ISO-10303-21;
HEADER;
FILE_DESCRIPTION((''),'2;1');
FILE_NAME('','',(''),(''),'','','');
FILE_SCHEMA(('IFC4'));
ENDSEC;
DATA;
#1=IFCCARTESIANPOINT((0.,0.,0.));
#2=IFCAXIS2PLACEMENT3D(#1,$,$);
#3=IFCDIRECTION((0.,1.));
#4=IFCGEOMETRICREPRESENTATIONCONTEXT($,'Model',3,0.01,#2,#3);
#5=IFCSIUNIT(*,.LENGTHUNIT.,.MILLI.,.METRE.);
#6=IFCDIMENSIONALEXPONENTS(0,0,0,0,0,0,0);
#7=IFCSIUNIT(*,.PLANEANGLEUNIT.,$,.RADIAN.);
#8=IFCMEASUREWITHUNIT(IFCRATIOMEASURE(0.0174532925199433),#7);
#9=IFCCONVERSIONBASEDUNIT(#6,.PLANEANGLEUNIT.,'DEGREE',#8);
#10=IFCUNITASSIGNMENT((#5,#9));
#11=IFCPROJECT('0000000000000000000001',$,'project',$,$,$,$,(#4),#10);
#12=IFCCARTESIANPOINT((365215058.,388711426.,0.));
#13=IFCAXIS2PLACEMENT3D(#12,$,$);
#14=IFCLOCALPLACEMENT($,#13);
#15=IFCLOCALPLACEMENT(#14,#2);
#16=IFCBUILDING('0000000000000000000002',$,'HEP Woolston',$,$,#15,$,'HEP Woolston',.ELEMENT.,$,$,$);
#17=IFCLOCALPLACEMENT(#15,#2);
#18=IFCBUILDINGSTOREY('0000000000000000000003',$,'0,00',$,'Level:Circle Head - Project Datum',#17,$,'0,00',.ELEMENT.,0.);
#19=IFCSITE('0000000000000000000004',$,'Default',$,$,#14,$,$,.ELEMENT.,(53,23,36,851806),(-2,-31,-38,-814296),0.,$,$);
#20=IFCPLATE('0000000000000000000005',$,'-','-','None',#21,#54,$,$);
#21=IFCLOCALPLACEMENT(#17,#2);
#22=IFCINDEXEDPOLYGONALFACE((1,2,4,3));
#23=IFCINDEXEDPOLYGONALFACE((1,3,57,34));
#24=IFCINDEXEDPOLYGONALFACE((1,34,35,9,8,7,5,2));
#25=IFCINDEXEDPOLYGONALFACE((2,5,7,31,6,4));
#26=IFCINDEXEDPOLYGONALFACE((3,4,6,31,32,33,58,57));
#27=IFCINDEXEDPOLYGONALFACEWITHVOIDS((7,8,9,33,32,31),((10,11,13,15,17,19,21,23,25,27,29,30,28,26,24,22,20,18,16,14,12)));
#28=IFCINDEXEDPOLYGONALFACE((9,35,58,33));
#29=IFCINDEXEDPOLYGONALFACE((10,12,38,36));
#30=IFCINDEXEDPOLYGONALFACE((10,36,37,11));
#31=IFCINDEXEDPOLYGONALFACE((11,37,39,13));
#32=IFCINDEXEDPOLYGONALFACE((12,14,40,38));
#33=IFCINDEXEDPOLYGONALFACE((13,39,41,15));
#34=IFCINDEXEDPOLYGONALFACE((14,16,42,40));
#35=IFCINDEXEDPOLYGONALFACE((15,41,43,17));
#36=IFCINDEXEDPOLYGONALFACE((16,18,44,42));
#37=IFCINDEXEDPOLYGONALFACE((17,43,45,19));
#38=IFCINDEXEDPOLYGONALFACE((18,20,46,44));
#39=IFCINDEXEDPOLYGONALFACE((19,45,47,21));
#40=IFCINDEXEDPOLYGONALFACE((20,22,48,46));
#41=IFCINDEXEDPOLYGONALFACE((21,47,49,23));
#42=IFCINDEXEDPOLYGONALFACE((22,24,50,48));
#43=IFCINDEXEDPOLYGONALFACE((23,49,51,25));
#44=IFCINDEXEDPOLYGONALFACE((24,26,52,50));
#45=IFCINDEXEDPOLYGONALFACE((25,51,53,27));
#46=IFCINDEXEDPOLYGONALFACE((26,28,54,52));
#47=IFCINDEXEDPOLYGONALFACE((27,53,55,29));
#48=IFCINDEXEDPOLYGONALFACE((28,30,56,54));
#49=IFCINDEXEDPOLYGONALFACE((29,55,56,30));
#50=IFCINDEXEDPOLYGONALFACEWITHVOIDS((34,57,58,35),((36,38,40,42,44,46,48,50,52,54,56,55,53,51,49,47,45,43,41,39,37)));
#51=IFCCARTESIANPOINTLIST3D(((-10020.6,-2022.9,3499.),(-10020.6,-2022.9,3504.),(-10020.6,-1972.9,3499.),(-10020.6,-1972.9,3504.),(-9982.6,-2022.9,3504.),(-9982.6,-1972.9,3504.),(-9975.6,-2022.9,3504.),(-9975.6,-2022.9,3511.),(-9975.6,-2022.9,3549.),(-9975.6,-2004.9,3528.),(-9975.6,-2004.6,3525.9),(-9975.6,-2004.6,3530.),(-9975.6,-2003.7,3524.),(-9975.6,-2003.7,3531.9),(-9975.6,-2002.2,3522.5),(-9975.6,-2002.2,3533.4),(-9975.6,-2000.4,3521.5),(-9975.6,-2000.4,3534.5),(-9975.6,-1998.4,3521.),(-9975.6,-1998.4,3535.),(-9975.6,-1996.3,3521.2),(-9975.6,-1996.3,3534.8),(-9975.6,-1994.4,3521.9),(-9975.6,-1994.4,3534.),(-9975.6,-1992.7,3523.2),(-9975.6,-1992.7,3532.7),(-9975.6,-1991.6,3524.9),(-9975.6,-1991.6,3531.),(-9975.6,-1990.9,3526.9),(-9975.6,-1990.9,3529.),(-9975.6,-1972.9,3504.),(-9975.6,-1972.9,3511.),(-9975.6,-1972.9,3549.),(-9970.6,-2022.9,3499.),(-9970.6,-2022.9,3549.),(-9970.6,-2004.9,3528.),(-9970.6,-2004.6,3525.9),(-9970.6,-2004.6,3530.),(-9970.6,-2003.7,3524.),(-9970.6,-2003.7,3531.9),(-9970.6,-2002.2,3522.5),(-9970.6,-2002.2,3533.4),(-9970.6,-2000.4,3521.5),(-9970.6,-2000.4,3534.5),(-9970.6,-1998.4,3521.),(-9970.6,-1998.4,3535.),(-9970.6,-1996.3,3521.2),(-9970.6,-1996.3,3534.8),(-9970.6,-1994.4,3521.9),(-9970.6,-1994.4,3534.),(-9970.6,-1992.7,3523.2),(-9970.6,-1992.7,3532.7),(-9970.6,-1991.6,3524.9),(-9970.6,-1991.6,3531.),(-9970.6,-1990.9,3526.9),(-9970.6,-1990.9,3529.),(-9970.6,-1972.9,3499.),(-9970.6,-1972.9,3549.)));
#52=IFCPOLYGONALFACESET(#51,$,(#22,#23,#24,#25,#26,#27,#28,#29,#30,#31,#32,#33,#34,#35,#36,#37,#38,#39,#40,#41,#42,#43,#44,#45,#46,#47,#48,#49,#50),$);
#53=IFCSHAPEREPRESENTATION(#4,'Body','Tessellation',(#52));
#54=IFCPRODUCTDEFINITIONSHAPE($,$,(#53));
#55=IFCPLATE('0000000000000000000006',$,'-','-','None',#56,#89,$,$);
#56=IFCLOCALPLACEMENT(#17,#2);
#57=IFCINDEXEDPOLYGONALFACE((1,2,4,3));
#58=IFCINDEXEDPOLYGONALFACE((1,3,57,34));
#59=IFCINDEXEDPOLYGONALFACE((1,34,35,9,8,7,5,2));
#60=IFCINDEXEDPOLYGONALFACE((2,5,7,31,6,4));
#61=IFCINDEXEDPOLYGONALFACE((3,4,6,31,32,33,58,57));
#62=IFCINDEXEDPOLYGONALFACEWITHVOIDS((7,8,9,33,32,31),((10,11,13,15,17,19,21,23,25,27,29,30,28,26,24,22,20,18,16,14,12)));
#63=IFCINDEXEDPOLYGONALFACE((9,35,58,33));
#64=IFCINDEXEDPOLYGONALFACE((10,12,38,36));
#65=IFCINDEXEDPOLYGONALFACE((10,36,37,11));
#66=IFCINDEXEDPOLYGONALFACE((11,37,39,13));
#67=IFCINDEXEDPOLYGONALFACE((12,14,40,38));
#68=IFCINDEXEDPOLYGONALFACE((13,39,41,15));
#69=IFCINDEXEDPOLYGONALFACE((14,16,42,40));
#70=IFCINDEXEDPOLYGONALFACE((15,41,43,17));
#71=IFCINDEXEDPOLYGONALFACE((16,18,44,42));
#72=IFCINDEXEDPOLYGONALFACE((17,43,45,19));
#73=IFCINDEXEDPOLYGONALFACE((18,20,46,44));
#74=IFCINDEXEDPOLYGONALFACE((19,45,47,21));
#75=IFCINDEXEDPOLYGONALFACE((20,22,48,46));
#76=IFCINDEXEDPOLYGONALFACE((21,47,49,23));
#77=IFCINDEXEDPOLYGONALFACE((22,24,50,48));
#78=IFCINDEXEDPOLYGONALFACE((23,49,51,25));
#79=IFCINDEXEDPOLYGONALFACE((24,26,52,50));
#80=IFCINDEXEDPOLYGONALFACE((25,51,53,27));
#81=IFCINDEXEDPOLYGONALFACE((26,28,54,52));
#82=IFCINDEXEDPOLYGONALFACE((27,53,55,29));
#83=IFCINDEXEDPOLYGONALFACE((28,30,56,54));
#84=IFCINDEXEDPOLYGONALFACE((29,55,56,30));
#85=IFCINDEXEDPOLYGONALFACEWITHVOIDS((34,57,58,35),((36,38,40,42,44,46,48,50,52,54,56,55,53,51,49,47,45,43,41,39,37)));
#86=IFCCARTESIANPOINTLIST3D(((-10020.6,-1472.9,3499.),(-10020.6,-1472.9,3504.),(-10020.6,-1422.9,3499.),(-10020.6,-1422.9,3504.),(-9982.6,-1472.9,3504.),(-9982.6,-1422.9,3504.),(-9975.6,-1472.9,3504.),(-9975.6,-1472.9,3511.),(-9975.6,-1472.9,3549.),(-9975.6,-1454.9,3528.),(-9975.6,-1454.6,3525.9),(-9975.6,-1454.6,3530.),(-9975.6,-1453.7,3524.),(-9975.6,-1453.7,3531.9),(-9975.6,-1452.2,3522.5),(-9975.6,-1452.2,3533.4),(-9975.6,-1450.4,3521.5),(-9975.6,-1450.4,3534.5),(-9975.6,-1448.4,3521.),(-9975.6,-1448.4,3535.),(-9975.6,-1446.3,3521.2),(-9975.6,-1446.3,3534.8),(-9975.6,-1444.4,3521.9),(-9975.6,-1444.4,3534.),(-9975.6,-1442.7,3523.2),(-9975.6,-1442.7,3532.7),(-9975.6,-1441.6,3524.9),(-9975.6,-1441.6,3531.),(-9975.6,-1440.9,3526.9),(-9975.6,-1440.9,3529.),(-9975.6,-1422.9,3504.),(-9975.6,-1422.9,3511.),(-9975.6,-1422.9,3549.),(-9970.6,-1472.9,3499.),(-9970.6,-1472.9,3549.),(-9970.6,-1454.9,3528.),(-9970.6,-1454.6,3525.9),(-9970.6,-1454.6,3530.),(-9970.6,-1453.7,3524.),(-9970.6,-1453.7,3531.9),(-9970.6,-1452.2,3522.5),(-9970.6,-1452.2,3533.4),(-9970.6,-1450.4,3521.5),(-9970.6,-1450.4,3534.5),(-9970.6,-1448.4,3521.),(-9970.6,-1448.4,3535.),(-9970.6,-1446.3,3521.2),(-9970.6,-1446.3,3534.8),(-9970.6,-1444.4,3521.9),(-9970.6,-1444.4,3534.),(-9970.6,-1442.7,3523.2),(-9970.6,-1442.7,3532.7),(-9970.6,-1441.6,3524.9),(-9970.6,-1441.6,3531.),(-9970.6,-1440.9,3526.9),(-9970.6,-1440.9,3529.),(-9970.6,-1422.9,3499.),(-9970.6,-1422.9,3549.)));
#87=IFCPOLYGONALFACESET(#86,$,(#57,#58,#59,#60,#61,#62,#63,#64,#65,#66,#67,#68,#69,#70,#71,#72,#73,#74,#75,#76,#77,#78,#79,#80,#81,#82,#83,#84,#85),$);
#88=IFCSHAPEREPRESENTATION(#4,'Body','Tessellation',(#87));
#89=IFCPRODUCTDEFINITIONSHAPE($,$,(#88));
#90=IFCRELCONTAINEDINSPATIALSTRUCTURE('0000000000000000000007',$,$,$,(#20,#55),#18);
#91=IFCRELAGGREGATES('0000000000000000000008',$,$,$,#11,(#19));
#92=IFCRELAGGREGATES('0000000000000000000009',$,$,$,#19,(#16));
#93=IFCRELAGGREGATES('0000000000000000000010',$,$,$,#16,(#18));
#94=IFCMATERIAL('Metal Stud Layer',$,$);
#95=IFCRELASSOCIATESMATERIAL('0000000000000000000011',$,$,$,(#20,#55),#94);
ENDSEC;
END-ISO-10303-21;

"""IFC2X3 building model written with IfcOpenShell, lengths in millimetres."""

from ifc_helpers import new_model, entity, si_unit, converted_unit, point, direction, frame, frame_2d, origin, origin_with_axes, origin_2d_with_axis, place, context, project, spatial, polyline, circle_curve, line_curve, trimmed, segment, composite_curve, circle, outline, extrude, material, element, save


model = new_model("IFC2X3")

# Units and contexts
model_context = context("Model", 3, precision=0.01, world=origin(), true_north=direction((0.0, 1.0)))
ifc_project = project(units=[si_unit("LENGTHUNIT", "METRE", prefix="MILLI"), converted_unit("PLANEANGLEUNIT", "DEGREE", entity("IfcRatioMeasure", 0.0174532925199433), si_unit("PLANEANGLEUNIT", "RADIAN"), dimensions=[0, 0, 0, 0, 0, 0, 0])], contexts=[model_context])

# Site, building, storey
site_placement = place(None, frame((365215058.0, 388711426.0, 0.0)))
site = spatial("IfcSite", under=ifc_project, at=site_placement, Name="Default", CompositionType="ELEMENT", RefLatitude=(53, 23, 36, 851806), RefLongitude=(-2, -31, -38, -814296), RefElevation=0.0)
building_placement = place(site_placement, origin())
building = spatial("IfcBuilding", under=site, at=building_placement, Name="HEP Woolston", LongName="HEP Woolston", CompositionType="ELEMENT")
storey_placement = place(building_placement, origin())
storey = spatial("IfcBuildingStorey", under=building, at=storey_placement, Name="0,00", ObjectType="Level:Circle Head - Project Datum", LongName="0,00", CompositionType="ELEMENT", Elevation=0.0)

# Plates, openings
ifc_material = material(Name="Metal Stud Layer")
plate_1_placement = place(storey_placement, frame((-9970.6, -2022.9, 3499.0), z_axis=(0.0, 1.0, 0.0), x_axis=(-1.0, 0.0, 0.0)))
plate_1 = element("IfcPlate", 1, at=plate_1_placement, inside=storey, material=ifc_material, Name="-", Description="-", ObjectType="None", context=model_context, shape_type="SweptSolid", body=[
    extrude(outline(polyline([(0.0, 0.0), (50.0, 0.0), (50.0, 5.0), (5.0, 5.0), (5.0, 50.0), (0.0, 50.0), (0.0, 0.0)])), origin_with_axes(), (0.0, 0.0, 1.0), 50.0),
])
opening_1_placement = place(plate_1_placement, frame((0.0, 0.0, 0.0), z_axis=(0.0, 0.0, 1.0), x_axis=(1.0, 0.0, 0.0)))
element("IfcOpeningElement", 2, at=opening_1_placement, cuts=plate_1, ObjectType="Opening", context=model_context, shape_type="SweptSolid", body=[
    extrude(outline(composite_curve([segment(trimmed(line_curve((50.0, 5.0), (1.0, 0.0), 3.532613), [point((50.0, 5.0))], [point((46.5, 5.0))], True, "CARTESIAN"), True, "CONTINUOUS"), segment(trimmed(circle_curve(frame_2d((46.5, 1.5), x_axis=(-1.0, 0.0)), 3.5), [point((46.5, 5.0))], [point((50.0, 1.5))], False, "CARTESIAN"), True, "CONTINUOUS"), segment(trimmed(line_curve((50.0, 1.5), (0.0, -1.0), 3.532613), [point((50.0, 1.5))], [point((50.0, 5.0))], True, "CARTESIAN"), True, "CONTINUOUS")], self_intersect="UNKNOWN")), origin(), (0.0, 0.0, 1.0), 50.0),
])
opening_2_placement = place(plate_1_placement, origin_with_axes())
element("IfcOpeningElement", 3, at=opening_2_placement, cuts=plate_1, ObjectType="Opening", context=model_context, shape_type="SweptSolid", body=[
    extrude(outline(composite_curve([segment(trimmed(line_curve((5.0, 5.0), (0.0, -1.0), 7.046301), [point((5.0, 5.0))], [point((5.0, 12.0))], False, "CARTESIAN"), True, "CONTINUOUS"), segment(trimmed(circle_curve(frame_2d((12.0, 12.0), x_axis=(1.0, 0.0)), 7.0), [point((5.0, 12.0))], [point((12.0, 5.0))], True, "CARTESIAN"), True, "CONTINUOUS"), segment(trimmed(line_curve((12.0, 5.0), (1.0, 0.0), 7.046301), [point((12.0, 5.0))], [point((5.0, 5.0))], False, "CARTESIAN"), True, "CONTINUOUS")], self_intersect="UNKNOWN")), origin(), (0.0, 0.0, 1.0), 50.0),
])
opening_3_placement = place(plate_1_placement, frame((0.0, 0.0, 0.0), z_axis=(0.0, 0.0, 1.0), x_axis=(1.0, 0.0, 0.0)))
element("IfcOpeningElement", 4, at=opening_3_placement, cuts=plate_1, ObjectType="Opening", context=model_context, shape_type="SweptSolid", body=[
    extrude(outline(composite_curve([segment(trimmed(line_curve((5.0, 50.0), (1.0, 0.0), 3.4874), [point((5.0, 50.0))], [point((1.5, 50.0))], True, "CARTESIAN"), True, "CONTINUOUS"), segment(trimmed(circle_curve(frame_2d((1.5, 46.5), x_axis=(-1.0, 0.0)), 3.5), [point((1.5, 50.0))], [point((5.0, 46.5))], False, "CARTESIAN"), True, "CONTINUOUS"), segment(trimmed(line_curve((5.0, 46.5), (0.0, -1.0), 3.4874), [point((5.0, 46.5))], [point((5.0, 50.0))], True, "CARTESIAN"), True, "CONTINUOUS")], self_intersect="UNKNOWN")), origin(), (0.0, 0.0, 1.0), 50.0),
])
opening_4_placement = place(plate_1_placement, frame((-0.5, 29.0, 25.0), z_axis=(1.0, 0.0, 0.0), x_axis=(0.0, 0.0, -1.0)))
element("IfcOpeningElement", 5, at=opening_4_placement, cuts=plate_1, ObjectType="Opening", context=model_context, shape_type="SweptSolid", body=[
    extrude(circle(Radius=7.0, at=origin_2d_with_axis()), origin(), (0.0, 0.0, 1.0), 6.0),
])
plate_2_placement = place(storey_placement, frame((-9970.6, -1472.9, 3499.0), z_axis=(0.0, 1.0, 0.0), x_axis=(-1.0, 0.0, 0.0)))
plate_2 = element("IfcPlate", 6, at=plate_2_placement, inside=storey, material=ifc_material, Name="-", Description="-", ObjectType="None", context=model_context, shape_type="SweptSolid", body=[
    extrude(outline(polyline([(0.0, 0.0), (50.0, 0.0), (50.0, 5.0), (5.0, 5.0), (5.0, 50.0), (0.0, 50.0), (0.0, 0.0)])), origin_with_axes(), (0.0, 0.0, 1.0), 50.0),
])
opening_5_placement = place(plate_2_placement, frame((0.0, 0.0, 0.0), z_axis=(0.0, 0.0, 1.0), x_axis=(1.0, 0.0, 0.0)))
element("IfcOpeningElement", 7, at=opening_5_placement, cuts=plate_2, ObjectType="Opening", context=model_context, shape_type="SweptSolid", body=[
    extrude(outline(composite_curve([segment(trimmed(line_curve((50.0, 5.0), (1.0, 0.0), 3.532613), [point((50.0, 5.0))], [point((46.5, 5.0))], True, "CARTESIAN"), True, "CONTINUOUS"), segment(trimmed(circle_curve(frame_2d((46.5, 1.5), x_axis=(-1.0, 0.0)), 3.5), [point((46.5, 5.0))], [point((50.0, 1.5))], False, "CARTESIAN"), True, "CONTINUOUS"), segment(trimmed(line_curve((50.0, 1.5), (0.0, -1.0), 3.532613), [point((50.0, 1.5))], [point((50.0, 5.0))], True, "CARTESIAN"), True, "CONTINUOUS")], self_intersect="UNKNOWN")), origin(), (0.0, 0.0, 1.0), 50.0),
])
opening_6_placement = place(plate_2_placement, origin_with_axes())
element("IfcOpeningElement", 8, at=opening_6_placement, cuts=plate_2, ObjectType="Opening", context=model_context, shape_type="SweptSolid", body=[
    extrude(outline(composite_curve([segment(trimmed(line_curve((5.0, 5.0), (0.0, -1.0), 7.046301), [point((5.0, 5.0))], [point((5.0, 12.0))], False, "CARTESIAN"), True, "CONTINUOUS"), segment(trimmed(circle_curve(frame_2d((12.0, 12.0), x_axis=(1.0, 0.0)), 7.0), [point((5.0, 12.0))], [point((12.0, 5.0))], True, "CARTESIAN"), True, "CONTINUOUS"), segment(trimmed(line_curve((12.0, 5.0), (1.0, 0.0), 7.046301), [point((12.0, 5.0))], [point((5.0, 5.0))], False, "CARTESIAN"), True, "CONTINUOUS")], self_intersect="UNKNOWN")), origin(), (0.0, 0.0, 1.0), 50.0),
])
opening_7_placement = place(plate_2_placement, frame((0.0, 0.0, 0.0), z_axis=(0.0, 0.0, 1.0), x_axis=(1.0, 0.0, 0.0)))
element("IfcOpeningElement", 9, at=opening_7_placement, cuts=plate_2, ObjectType="Opening", context=model_context, shape_type="SweptSolid", body=[
    extrude(outline(composite_curve([segment(trimmed(line_curve((5.0, 50.0), (1.0, 0.0), 3.4874), [point((5.0, 50.0))], [point((1.5, 50.0))], True, "CARTESIAN"), True, "CONTINUOUS"), segment(trimmed(circle_curve(frame_2d((1.5, 46.5), x_axis=(-1.0, 0.0)), 3.5), [point((1.5, 50.0))], [point((5.0, 46.5))], False, "CARTESIAN"), True, "CONTINUOUS"), segment(trimmed(line_curve((5.0, 46.5), (0.0, -1.0), 3.4874), [point((5.0, 46.5))], [point((5.0, 50.0))], True, "CARTESIAN"), True, "CONTINUOUS")], self_intersect="UNKNOWN")), origin(), (0.0, 0.0, 1.0), 50.0),
])
opening_8_placement = place(plate_2_placement, frame((-0.5, 29.0, 25.0), z_axis=(1.0, 0.0, 0.0), x_axis=(0.0, 0.0, -1.0)))
element("IfcOpeningElement", 10, at=opening_8_placement, cuts=plate_2, ObjectType="Opening", context=model_context, shape_type="SweptSolid", body=[
    extrude(circle(Radius=7.0, at=origin_2d_with_axis()), origin(), (0.0, 0.0, 1.0), 6.0),
])

save(model, "model.ifc")
